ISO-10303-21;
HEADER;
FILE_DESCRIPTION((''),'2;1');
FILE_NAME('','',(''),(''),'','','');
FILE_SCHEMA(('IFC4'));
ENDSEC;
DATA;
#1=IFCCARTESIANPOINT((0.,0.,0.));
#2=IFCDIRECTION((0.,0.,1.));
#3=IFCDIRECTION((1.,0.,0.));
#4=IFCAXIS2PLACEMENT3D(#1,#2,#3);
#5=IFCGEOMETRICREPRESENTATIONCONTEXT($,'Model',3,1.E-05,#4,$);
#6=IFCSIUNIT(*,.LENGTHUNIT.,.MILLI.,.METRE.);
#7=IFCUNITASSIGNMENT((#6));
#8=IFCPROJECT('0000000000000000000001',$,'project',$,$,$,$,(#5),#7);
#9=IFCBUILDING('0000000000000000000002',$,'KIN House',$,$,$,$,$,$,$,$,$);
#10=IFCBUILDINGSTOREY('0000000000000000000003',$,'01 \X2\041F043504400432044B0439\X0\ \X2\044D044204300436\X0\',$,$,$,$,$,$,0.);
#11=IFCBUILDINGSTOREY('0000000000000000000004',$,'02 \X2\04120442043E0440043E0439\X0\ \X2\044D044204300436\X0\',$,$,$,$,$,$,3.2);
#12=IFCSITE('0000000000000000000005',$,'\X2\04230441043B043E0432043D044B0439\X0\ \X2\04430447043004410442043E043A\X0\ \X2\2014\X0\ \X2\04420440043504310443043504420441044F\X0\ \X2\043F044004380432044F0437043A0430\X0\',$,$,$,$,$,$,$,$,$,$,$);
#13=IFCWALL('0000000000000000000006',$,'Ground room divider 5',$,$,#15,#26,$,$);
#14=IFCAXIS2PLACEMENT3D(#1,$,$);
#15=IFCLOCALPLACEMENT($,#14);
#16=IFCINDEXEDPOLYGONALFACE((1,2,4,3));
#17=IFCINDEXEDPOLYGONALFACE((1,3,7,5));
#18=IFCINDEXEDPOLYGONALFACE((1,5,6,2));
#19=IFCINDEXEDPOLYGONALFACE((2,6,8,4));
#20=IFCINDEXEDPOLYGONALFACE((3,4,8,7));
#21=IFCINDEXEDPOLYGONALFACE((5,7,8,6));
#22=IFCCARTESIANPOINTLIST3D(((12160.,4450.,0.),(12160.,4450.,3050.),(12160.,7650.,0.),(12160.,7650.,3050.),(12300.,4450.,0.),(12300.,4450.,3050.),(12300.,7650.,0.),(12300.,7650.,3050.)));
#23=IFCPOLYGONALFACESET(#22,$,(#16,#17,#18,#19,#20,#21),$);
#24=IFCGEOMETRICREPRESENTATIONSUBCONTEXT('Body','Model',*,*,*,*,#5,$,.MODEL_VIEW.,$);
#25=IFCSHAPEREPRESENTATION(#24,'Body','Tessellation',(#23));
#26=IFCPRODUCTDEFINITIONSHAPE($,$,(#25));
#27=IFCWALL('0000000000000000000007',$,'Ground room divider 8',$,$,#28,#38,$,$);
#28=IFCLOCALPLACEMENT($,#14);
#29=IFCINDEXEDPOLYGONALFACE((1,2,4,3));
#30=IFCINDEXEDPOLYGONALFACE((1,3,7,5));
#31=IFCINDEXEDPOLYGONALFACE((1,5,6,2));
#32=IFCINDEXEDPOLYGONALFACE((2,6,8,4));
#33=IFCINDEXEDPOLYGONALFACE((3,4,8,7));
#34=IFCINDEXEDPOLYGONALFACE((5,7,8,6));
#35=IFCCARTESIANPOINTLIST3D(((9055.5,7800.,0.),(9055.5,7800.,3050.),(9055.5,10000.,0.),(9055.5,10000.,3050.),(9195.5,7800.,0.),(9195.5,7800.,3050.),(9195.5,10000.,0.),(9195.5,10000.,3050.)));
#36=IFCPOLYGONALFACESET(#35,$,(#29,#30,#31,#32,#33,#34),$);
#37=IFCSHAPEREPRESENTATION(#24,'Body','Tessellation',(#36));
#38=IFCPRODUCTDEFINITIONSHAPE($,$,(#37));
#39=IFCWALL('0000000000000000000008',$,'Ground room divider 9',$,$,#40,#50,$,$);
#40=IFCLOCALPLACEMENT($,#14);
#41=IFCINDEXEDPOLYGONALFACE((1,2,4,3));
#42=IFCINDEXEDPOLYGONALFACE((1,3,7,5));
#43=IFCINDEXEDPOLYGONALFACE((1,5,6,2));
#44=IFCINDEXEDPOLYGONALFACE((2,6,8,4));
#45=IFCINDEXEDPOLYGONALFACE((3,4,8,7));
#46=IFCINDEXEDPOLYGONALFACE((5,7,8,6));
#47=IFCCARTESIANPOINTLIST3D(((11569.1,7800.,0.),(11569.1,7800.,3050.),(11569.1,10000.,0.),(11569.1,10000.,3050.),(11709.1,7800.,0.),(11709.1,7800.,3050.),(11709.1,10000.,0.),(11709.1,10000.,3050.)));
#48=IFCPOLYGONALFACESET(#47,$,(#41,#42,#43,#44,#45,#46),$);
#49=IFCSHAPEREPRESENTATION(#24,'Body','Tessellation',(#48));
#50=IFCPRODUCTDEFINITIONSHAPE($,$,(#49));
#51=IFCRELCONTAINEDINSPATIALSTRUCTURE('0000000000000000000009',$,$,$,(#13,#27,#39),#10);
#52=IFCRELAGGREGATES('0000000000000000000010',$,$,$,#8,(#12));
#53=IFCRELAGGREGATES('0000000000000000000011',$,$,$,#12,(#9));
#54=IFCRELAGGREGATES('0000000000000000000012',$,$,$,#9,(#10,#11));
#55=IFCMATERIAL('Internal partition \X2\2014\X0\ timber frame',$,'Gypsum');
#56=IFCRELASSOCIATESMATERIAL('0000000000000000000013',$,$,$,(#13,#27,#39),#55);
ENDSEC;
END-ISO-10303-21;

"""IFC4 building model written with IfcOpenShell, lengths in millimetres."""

from ifc_helpers import new_model, si_unit, frame, origin_with_axes, place, context, subcontext, project, spatial, indexed_curve, outline, extrude, material, element, save


model = new_model("IFC4")

# Units and contexts
model_context = context("Model", 3, precision=1e-05, world=origin_with_axes())
body_context = subcontext(model_context, "Body", "Model", "MODEL_VIEW")
ifc_project = project(units=[si_unit("LENGTHUNIT", "METRE", prefix="MILLI")], contexts=[model_context])

# Site, building, storey
site = spatial("IfcSite", under=ifc_project, Name="Условный участок — требуется привязка")
building = spatial("IfcBuilding", under=site, Name="KIN House")
storey_1 = spatial("IfcBuildingStorey", under=building, Name="01 Первый этаж", Elevation=0.0)

# Shared definitions
storey_2 = spatial("IfcBuildingStorey", under=building, Name="02 Второй этаж", Elevation=3.2)

# Walls
ifc_material_1 = material(Name="Internal partition — timber frame", Category="Gypsum")
for number, where, z_axis, x_axis, name in (
    (1, (12300.0, 4450.0, 0.0), (0.0, 0.0, 1.0), (0.0, 1.0, 0.0), "Ground room divider 5"),
):
    element("IfcWall", number, at=place(None, frame(where, z_axis=z_axis, x_axis=x_axis)), inside=storey_1, material=ifc_material_1, Name=name, context=body_context, shape_type="SweptSolid", body=[
        extrude(outline(indexed_curve([(0.0, 0.0), (0.0, 140.0), (3200.0, 140.0), (3200.0, 0.0), (0.0, 0.0)], self_intersect=False)), origin_with_axes(), (0.0, 0.0, 1.0), 3050.0),
    ])
for number, where, z_axis, x_axis, name in (
    (2, (9195.5, 7800.0, 0.0), (0.0, 0.0, 1.0), (0.0, 1.0, 0.0), "Ground room divider 8"),
    (3, (11709.1, 7800.0, 0.0), (0.0, 0.0, 1.0), (0.0, 1.0, 0.0), "Ground room divider 9"),
):
    element("IfcWall", number, at=place(None, frame(where, z_axis=z_axis, x_axis=x_axis)), inside=storey_1, material=ifc_material_1, Name=name, context=body_context, shape_type="SweptSolid", body=[
        extrude(outline(indexed_curve([(0.0, 0.0), (0.0, 140.0), (2200.0, 140.0), (2200.0, 0.0), (0.0, 0.0)], self_intersect=False)), origin_with_axes(), (0.0, 0.0, 1.0), 3050.0),
    ])

save(model, "model.ifc")
